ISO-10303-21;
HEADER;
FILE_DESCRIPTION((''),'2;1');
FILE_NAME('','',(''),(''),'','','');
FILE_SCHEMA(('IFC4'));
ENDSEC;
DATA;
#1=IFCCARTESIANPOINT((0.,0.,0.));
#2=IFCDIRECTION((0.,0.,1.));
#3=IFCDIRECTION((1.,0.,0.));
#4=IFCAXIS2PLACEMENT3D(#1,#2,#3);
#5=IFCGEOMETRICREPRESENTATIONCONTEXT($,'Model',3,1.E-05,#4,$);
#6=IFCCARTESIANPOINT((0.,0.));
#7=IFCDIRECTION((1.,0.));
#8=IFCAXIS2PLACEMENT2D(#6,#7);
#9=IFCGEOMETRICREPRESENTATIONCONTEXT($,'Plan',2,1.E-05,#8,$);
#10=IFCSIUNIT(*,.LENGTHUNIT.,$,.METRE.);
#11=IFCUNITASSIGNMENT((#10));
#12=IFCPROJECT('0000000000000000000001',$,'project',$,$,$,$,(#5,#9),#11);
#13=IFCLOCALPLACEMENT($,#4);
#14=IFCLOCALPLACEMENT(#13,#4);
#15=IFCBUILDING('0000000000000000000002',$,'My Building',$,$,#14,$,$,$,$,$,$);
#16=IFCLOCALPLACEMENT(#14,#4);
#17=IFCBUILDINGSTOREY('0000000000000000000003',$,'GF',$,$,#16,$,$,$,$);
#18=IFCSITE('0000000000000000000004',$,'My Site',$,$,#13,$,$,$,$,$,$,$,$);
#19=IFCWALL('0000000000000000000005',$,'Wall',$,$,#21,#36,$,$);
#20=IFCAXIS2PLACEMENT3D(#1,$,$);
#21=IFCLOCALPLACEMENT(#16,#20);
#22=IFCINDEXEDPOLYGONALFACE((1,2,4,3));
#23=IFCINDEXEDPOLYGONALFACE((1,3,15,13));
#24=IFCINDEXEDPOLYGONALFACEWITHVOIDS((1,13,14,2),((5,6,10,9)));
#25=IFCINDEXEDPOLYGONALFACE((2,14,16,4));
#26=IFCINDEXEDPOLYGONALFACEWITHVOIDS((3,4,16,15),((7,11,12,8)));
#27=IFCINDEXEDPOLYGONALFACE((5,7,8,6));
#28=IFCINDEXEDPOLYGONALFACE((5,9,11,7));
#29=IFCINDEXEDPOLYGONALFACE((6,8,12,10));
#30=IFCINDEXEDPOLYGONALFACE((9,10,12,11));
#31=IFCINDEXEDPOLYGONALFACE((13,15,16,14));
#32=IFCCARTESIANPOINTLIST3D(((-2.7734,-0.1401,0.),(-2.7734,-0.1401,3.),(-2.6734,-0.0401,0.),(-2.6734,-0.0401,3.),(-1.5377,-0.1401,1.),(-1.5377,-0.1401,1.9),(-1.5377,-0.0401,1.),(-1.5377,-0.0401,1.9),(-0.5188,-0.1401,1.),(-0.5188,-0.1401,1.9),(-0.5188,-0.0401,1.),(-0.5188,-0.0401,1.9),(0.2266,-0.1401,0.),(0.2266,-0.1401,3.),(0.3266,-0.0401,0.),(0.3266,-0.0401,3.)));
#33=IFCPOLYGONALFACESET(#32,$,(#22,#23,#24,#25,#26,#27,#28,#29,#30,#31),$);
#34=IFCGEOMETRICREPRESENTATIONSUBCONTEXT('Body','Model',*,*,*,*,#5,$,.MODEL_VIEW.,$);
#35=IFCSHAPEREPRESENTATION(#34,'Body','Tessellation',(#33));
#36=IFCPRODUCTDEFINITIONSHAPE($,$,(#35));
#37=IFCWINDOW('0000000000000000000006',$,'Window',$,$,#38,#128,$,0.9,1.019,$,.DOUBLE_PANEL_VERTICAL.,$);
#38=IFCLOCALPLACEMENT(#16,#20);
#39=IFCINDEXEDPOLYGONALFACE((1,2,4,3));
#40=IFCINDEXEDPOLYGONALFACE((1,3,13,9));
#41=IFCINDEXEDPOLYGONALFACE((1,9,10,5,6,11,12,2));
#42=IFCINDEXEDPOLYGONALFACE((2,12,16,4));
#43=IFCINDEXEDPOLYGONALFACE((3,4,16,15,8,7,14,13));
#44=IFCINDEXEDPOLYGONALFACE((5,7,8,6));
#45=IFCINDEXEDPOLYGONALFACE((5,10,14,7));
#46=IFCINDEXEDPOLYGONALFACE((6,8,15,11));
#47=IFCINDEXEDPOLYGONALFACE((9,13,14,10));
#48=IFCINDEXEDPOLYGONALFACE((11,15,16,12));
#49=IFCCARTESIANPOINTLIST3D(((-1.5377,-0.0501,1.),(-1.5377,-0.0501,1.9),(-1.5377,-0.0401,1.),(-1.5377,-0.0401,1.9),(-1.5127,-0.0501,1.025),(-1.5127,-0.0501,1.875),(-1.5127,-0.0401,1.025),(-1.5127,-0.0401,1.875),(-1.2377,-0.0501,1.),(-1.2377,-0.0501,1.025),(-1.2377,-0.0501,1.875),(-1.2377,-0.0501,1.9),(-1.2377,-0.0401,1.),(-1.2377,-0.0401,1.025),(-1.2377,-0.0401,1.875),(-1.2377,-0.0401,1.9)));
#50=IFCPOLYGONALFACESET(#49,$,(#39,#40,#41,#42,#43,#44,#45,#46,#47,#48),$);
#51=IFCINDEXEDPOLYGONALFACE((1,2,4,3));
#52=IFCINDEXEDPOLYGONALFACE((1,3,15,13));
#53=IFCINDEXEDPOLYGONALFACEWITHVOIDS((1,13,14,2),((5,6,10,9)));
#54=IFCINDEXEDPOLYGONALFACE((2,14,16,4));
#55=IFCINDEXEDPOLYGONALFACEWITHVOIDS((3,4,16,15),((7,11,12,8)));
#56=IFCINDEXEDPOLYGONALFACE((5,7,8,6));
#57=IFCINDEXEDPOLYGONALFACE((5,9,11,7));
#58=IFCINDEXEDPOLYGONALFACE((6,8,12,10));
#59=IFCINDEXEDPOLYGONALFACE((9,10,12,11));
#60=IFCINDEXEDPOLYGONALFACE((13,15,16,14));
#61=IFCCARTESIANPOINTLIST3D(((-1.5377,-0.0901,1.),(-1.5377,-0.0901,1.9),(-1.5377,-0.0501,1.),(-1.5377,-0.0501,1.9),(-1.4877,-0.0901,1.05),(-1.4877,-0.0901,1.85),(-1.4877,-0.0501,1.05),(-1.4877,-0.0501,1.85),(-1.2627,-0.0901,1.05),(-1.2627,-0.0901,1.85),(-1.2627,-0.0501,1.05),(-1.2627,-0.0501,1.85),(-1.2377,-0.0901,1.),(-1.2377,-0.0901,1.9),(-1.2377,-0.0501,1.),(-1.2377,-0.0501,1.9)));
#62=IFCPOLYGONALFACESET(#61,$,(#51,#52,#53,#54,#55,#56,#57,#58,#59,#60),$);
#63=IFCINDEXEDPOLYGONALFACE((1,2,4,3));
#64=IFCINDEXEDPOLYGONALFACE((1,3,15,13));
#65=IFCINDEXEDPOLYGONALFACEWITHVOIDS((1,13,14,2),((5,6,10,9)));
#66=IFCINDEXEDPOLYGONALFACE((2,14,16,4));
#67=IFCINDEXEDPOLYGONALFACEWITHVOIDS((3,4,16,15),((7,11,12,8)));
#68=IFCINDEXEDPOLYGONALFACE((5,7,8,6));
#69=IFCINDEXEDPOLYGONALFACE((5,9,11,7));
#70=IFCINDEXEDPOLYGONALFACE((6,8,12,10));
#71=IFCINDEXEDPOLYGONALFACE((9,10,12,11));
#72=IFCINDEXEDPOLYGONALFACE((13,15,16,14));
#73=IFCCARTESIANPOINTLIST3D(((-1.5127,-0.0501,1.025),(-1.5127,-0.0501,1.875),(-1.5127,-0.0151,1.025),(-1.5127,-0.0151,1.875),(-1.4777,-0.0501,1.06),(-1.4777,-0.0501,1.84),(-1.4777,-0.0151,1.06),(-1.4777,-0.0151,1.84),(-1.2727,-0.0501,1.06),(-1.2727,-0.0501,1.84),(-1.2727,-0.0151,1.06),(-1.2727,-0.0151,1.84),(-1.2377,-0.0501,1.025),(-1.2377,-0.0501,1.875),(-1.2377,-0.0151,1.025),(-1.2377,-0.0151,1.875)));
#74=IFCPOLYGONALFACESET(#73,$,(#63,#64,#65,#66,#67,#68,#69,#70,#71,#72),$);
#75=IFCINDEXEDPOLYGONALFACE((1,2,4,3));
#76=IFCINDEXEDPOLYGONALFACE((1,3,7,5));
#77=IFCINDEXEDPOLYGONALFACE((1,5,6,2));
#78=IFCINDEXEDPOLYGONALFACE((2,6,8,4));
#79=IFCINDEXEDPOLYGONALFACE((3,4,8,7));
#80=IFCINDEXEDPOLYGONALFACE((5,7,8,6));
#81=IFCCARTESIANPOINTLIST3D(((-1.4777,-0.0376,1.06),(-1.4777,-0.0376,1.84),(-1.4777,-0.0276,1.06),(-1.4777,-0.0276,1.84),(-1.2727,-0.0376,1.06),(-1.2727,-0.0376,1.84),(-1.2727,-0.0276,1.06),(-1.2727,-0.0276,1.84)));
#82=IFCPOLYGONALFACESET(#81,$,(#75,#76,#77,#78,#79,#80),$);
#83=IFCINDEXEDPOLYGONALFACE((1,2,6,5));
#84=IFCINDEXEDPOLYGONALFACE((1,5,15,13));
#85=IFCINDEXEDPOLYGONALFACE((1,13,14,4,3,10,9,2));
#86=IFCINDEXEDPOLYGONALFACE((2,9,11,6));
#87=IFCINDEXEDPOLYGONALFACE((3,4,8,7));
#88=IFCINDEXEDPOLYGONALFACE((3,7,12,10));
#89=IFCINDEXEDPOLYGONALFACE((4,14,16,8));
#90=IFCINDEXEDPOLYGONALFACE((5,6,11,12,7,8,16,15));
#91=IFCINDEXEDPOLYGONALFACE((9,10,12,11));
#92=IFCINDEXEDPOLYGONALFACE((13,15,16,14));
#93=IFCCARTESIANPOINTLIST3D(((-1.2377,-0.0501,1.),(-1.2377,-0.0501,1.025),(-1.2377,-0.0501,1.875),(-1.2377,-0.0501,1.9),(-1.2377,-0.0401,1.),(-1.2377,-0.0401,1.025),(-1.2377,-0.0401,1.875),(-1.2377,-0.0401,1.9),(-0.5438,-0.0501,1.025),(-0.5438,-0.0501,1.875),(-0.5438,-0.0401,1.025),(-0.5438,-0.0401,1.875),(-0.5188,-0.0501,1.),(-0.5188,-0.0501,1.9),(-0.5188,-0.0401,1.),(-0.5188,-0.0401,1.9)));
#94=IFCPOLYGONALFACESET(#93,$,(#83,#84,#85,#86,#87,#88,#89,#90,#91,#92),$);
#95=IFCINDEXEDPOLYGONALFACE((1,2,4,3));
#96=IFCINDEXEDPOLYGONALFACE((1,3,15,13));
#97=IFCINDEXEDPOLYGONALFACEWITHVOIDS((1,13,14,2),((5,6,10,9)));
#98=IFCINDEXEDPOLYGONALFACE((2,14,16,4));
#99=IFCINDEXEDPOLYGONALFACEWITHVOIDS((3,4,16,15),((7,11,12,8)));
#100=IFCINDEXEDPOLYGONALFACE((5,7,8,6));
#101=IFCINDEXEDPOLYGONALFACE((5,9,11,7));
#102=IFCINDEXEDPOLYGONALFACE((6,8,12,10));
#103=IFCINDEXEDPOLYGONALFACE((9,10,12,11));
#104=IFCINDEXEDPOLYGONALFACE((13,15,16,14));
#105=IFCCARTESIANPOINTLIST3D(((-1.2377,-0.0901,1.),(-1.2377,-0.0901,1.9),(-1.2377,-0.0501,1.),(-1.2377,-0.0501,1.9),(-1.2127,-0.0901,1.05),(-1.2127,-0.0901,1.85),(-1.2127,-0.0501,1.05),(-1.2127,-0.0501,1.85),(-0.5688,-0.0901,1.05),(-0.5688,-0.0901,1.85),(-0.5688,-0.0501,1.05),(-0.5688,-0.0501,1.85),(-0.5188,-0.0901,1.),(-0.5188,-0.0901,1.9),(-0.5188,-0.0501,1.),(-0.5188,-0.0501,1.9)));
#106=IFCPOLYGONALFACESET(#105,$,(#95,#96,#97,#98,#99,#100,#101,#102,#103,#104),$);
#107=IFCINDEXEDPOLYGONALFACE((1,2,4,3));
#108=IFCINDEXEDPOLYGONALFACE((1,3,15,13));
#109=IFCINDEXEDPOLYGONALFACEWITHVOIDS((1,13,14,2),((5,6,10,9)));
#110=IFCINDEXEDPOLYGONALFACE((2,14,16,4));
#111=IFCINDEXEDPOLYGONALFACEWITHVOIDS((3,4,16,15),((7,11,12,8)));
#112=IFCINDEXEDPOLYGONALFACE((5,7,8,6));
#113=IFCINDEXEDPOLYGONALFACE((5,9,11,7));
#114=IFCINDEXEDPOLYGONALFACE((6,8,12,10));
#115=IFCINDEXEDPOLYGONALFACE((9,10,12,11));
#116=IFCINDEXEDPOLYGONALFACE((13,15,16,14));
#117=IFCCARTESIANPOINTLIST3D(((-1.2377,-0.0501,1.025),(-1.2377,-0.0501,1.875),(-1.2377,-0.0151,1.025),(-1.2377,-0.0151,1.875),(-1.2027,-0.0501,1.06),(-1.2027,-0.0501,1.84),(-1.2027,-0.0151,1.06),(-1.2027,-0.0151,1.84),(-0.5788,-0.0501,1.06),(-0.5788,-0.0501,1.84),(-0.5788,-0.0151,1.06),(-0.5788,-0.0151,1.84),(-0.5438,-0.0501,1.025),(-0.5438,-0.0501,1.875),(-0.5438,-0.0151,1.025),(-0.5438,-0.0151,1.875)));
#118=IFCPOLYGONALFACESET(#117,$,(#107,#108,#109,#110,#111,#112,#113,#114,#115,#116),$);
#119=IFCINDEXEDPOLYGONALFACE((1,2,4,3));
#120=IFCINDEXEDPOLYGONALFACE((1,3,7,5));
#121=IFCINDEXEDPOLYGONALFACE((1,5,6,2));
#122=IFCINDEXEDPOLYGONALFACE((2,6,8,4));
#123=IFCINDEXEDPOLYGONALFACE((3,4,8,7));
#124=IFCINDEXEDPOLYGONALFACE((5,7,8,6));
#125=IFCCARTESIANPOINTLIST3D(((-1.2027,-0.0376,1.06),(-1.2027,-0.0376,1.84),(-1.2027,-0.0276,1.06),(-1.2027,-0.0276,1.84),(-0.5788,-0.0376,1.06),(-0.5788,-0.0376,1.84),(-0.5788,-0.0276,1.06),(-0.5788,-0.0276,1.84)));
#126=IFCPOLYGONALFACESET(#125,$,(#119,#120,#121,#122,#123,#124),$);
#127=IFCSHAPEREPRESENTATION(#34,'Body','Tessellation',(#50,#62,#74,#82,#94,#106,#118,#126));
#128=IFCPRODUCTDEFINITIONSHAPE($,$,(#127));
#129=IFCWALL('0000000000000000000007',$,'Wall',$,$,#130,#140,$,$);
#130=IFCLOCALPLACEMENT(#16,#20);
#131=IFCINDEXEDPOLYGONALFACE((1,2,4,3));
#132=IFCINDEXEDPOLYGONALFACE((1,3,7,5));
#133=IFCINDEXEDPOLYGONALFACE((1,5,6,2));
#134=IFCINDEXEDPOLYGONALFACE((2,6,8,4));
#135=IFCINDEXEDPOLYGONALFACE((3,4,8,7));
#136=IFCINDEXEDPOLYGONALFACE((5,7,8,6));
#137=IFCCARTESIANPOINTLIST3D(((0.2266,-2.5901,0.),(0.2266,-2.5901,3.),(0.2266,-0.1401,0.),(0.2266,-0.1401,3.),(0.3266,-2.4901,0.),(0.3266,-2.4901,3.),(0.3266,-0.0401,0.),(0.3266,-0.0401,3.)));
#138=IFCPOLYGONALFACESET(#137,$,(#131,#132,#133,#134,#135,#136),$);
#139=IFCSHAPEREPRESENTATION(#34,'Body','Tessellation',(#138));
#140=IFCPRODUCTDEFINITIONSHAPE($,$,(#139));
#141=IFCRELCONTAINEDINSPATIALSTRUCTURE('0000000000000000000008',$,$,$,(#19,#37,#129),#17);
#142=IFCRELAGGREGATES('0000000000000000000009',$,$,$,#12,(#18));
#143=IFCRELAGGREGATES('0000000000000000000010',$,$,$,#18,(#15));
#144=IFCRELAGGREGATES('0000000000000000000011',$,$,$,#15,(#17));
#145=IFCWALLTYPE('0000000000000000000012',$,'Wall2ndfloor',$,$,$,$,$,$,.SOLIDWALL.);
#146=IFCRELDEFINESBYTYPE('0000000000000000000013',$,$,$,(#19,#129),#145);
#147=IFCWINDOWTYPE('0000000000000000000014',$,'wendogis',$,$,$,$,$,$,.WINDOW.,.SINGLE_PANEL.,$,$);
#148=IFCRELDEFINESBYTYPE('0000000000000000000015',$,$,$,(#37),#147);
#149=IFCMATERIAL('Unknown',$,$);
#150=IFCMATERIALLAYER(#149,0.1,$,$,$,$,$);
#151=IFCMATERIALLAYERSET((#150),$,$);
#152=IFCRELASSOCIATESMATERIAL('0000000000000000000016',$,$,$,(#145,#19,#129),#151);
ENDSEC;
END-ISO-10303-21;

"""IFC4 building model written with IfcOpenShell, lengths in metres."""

from ifc_helpers import new_model, entity, si_unit, frame, origin_with_axes, origin_2d_with_axis, place, context, subcontext, project, spatial, line, indexed_curve, outline, extrude, shape, source, transform, mapped, material, layer, layer_set, layer_usage, type_object, type_shapes, element, fill, save


model = new_model("IFC4")

# Units and contexts
model_context = context("Model", 3, precision=1e-05, world=origin_with_axes())
plan_context = context("Plan", 2, precision=1e-05, world=origin_2d_with_axis())
body_context_1 = subcontext(model_context, "Body", "Model", "MODEL_VIEW")
body_context_2 = subcontext(plan_context, "Body", "Plan", "PLAN_VIEW")
ifc_project = project(units=[si_unit("LENGTHUNIT", "METRE")], contexts=[model_context, plan_context])

# Site, building, storey
site_placement = place(None, origin_with_axes())
site = spatial("IfcSite", under=ifc_project, at=site_placement, Name="My Site")
building_placement = place(site_placement, origin_with_axes())
building = spatial("IfcBuilding", under=site, at=building_placement, Name="My Building")
storey_placement = place(building_placement, origin_with_axes())
storey = spatial("IfcBuildingStorey", under=building, at=storey_placement, Name="GF")

# Shared definitions
ifc_material = material(Name="Unknown")

# Shared definitions
ifc_layer_1 = layer(ifc_material, 0.1)
ifc_layer_set_1 = layer_set([ifc_layer_1])
wall_type_1 = type_object("IfcWallType", Name="Wall2ndfloor", PredefinedType="SOLIDWALL", material=ifc_layer_set_1)

# Wall, opening, window
ifc_layer_usage_1 = layer_usage(ifc_layer_set_1, "AXIS2", "POSITIVE", 0.0)
wall_1_placement = place(storey_placement, frame((-2.7734, -0.1401, 0.0), z_axis=(0.0, 0.0, 1.0), x_axis=(1.0, 0.0, 0.0)))
wall_1 = element("IfcWall", 1, at=wall_1_placement, inside=storey, type_object=wall_type_1, material=ifc_layer_usage_1, Name="Wall", context=body_context_1, shape_type="SweptSolid", body=[
    extrude(outline(indexed_curve([(0.0, 0.0), (0.1, 0.1), (3.1, 0.1), (3.0, 0.0)], segments=[line(1, 2, 3, 4, 1)])), origin_with_axes(), (0.0, 0.0, 1.0), 3.0),
])
shared_shape_1 = source(origin_with_axes(), body_context_1, "Body", "SweptSolid", [
    extrude(outline(indexed_curve([(0.0, 0.0), (1.019, 0.0), (1.019, 0.9), (0.0, 0.9)], segments=[line(1, 2, 3, 4, 1)])), frame((0.0, -0.6, 0.0), z_axis=(0.0, -1.0, 0.0), x_axis=(1.0, 0.0, 0.0)), (0.0, 0.0, -1.0), 1.2),
])
opening_1_placement = place(wall_1_placement, frame((1.2356, 0.0, 1.0), z_axis=(0.0, 0.0, 1.0), x_axis=(1.0, 0.0, 0.0)))
opening_1 = element("IfcOpeningElement", 2, at=opening_1_placement, cuts=wall_1, PredefinedType="OPENING", context=body_context_1, shape_type="MappedRepresentation", body=[
    mapped(shared_shape_1, transform((0.0, 0.0, 0.0), x_axis=(1.0, 0.0, 0.0), y_axis=(0.0, 1.0, 0.0), z_axis=(0.0, 0.0, 1.0), scale=1.0)),
])
window_type_1 = type_object("IfcWindowType", Name="wendogis", PartitioningType="SINGLE_PANEL", PredefinedType="WINDOW")
shared_shape_2 = source(origin_with_axes(), body_context_1, "Body", "SweptSolid", [
    extrude(outline(indexed_curve([(0.3, 0.0), (0.0, 0.0), (0.0, 0.9), (0.3, 0.9), (0.3, 0.875), (0.025, 0.875), (0.025, 0.025), (0.3, 0.025)], segments=[line(1, 2, 3, 4, 5, 6, 7, 8, 1)])), frame((0.0, 0.09, 0.0), z_axis=(0.0, -1.0, 0.0), x_axis=(1.0, 0.0, 0.0)), (0.0, 0.0, -1.0), 0.01),
    extrude(outline(indexed_curve([(0.0, 0.0), (0.3, 0.0), (0.3, 0.9), (0.0, 0.9)], segments=[line(1, 2, 3, 4, 1)]), holes=[indexed_curve([(0.05, 0.05), (0.275, 0.05), (0.275, 0.85), (0.05, 0.85)], segments=[line(1, 2, 3, 4, 1)])]), frame((0.0, 0.05, 0.0), z_axis=(0.0, -1.0, 0.0), x_axis=(1.0, 0.0, 0.0)), (0.0, 0.0, -1.0), 0.04),
    extrude(outline(indexed_curve([(0.0, 0.0), (0.275, 0.0), (0.275, 0.85), (0.0, 0.85)], segments=[line(1, 2, 3, 4, 1)]), holes=[indexed_curve([(0.035, 0.035), (0.24, 0.035), (0.24, 0.815), (0.035, 0.815)], segments=[line(1, 2, 3, 4, 1)])]), frame((0.025, 0.09, 0.025), z_axis=(0.0, -1.0, 0.0), x_axis=(1.0, 0.0, 0.0)), (0.0, 0.0, -1.0), 0.035),
    extrude(outline(indexed_curve([(0.035, 0.035), (0.24, 0.035), (0.24, 0.815), (0.035, 0.815)], segments=[line(1, 2, 3, 4, 1)])), frame((0.025, 0.1025, 0.025), z_axis=(0.0, -1.0, 0.0), x_axis=(1.0, 0.0, 0.0)), (0.0, 0.0, -1.0), 0.01),
    extrude(outline(indexed_curve([(0.0, 0.9), (0.719, 0.9), (0.719, 0.0), (0.0, 0.0), (0.0, 0.025), (0.694, 0.025), (0.694, 0.875), (0.0, 0.875)], segments=[line(1, 2, 3, 4, 5, 6, 7, 8, 1)])), frame((0.3, 0.09, 0.0), z_axis=(0.0, -1.0, 0.0), x_axis=(1.0, 0.0, 0.0)), (0.0, 0.0, -1.0), 0.01),
    extrude(outline(indexed_curve([(0.0, 0.0), (0.719, 0.0), (0.719, 0.9), (0.0, 0.9)], segments=[line(1, 2, 3, 4, 1)]), holes=[indexed_curve([(0.025, 0.05), (0.669, 0.05), (0.669, 0.85), (0.025, 0.85)], segments=[line(1, 2, 3, 4, 1)])]), frame((0.3, 0.05, 0.0), z_axis=(0.0, -1.0, 0.0), x_axis=(1.0, 0.0, 0.0)), (0.0, 0.0, -1.0), 0.04),
    extrude(outline(indexed_curve([(0.0, 0.0), (0.694, 0.0), (0.694, 0.85), (0.0, 0.85)], segments=[line(1, 2, 3, 4, 1)]), holes=[indexed_curve([(0.035, 0.035), (0.659, 0.035), (0.659, 0.815), (0.035, 0.815)], segments=[line(1, 2, 3, 4, 1)])]), frame((0.3, 0.09, 0.025), z_axis=(0.0, -1.0, 0.0), x_axis=(1.0, 0.0, 0.0)), (0.0, 0.0, -1.0), 0.035),
    extrude(outline(indexed_curve([(0.035, 0.035), (0.659, 0.035), (0.659, 0.815), (0.035, 0.815)], segments=[line(1, 2, 3, 4, 1)])), frame((0.3, 0.1025, 0.025), z_axis=(0.0, -1.0, 0.0), x_axis=(1.0, 0.0, 0.0)), (0.0, 0.0, -1.0), 0.01),
])
shared_shape_3 = source(origin_with_axes(), body_context_2, "Body", "Curve2D", [
    entity("IfcIndexedPolyCurve", entity("IfcCartesianPointList2D", [[0.05, 0.05], [0.275, 0.05]])),
    entity("IfcIndexedPolyCurve", entity("IfcCartesianPointList2D", [[0.0, 0.1], [0.025, 0.1], [0.025, 0.09], [0.05, 0.09], [0.05, 0.05], [0.0, 0.05]]), [entity("IfcLineIndex", [1, 2, 3, 4, 5, 6, 1])]),
    entity("IfcIndexedPolyCurve", entity("IfcCartesianPointList2D", [[0.3, 0.1], [0.3, 0.1], [0.3, 0.09], [0.275, 0.09], [0.275, 0.05], [0.3, 0.05]])),
    entity("IfcIndexedPolyCurve", entity("IfcCartesianPointList2D", [[0.025, 0.09], [0.06, 0.09], [0.06, 0.125], [0.025, 0.125]]), [entity("IfcLineIndex", [1, 2, 3, 4, 1])]),
    entity("IfcIndexedPolyCurve", entity("IfcCartesianPointList2D", [[0.3, 0.09], [0.265, 0.09], [0.265, 0.125], [0.3, 0.125]]), [entity("IfcLineIndex", [1, 2, 3, 4, 1])]),
    entity("IfcIndexedPolyCurve", entity("IfcCartesianPointList2D", [[0.06, 0.09], [0.265, 0.09]])),
    entity("IfcIndexedPolyCurve", entity("IfcCartesianPointList2D", [[0.06, 0.125], [0.265, 0.125]])),
    entity("IfcIndexedPolyCurve", entity("IfcCartesianPointList2D", [[0.06, 0.1075], [0.265, 0.1075]])),
    entity("IfcIndexedPolyCurve", entity("IfcCartesianPointList2D", [[0.325, 0.05], [0.969, 0.05]])),
    entity("IfcIndexedPolyCurve", entity("IfcCartesianPointList2D", [[0.3, 0.1], [0.3, 0.1], [0.3, 0.09], [0.325, 0.09], [0.325, 0.05], [0.3, 0.05]])),
    entity("IfcIndexedPolyCurve", entity("IfcCartesianPointList2D", [[1.019, 0.1], [0.994, 0.1], [0.994, 0.09], [0.969, 0.09], [0.969, 0.05], [1.019, 0.05]]), [entity("IfcLineIndex", [1, 2, 3, 4, 5, 6, 1])]),
    entity("IfcIndexedPolyCurve", entity("IfcCartesianPointList2D", [[0.3, 0.09], [0.335, 0.09], [0.335, 0.125], [0.3, 0.125]]), [entity("IfcLineIndex", [1, 2, 3, 4, 1])]),
    entity("IfcIndexedPolyCurve", entity("IfcCartesianPointList2D", [[0.994, 0.09], [0.959, 0.09], [0.959, 0.125], [0.994, 0.125]]), [entity("IfcLineIndex", [1, 2, 3, 4, 1])]),
    entity("IfcIndexedPolyCurve", entity("IfcCartesianPointList2D", [[0.335, 0.09], [0.959, 0.09]])),
    entity("IfcIndexedPolyCurve", entity("IfcCartesianPointList2D", [[0.335, 0.125], [0.959, 0.125]])),
    entity("IfcIndexedPolyCurve", entity("IfcCartesianPointList2D", [[0.335, 0.1075], [0.959, 0.1075]])),
])
type_shapes(window_type_1, [shared_shape_2, shared_shape_3])
window_1_placement = place(opening_1_placement, frame((0.0, 0.0, 0.0), z_axis=(0.0, 0.0, 1.0), x_axis=(1.0, 0.0, 0.0)))
window_1 = element("IfcWindow", 3, at=window_1_placement, inside=storey, type_object=window_type_1, Name="Window", OverallHeight=0.9, OverallWidth=1.019, PartitioningType="DOUBLE_PANEL_VERTICAL", shapes=[
    shape(body_context_1, "Body", "MappedRepresentation", [mapped(shared_shape_2, transform((0.0, 0.0, 0.0), x_axis=(1.0, 0.0, 0.0), y_axis=(0.0, 1.0, 0.0), z_axis=(0.0, 0.0, 1.0), scale=1.0))]),
    shape(body_context_2, "Body", "MappedRepresentation", [mapped(shared_shape_3, transform((0.0, 0.0, 0.0), x_axis=(1.0, 0.0, 0.0), y_axis=(0.0, 1.0, 0.0), z_axis=(0.0, 0.0, 1.0), scale=1.0))]),
])
fill(opening_1, window_1)

# Wall
ifc_layer_usage_2 = layer_usage(ifc_layer_set_1, "AXIS2", "POSITIVE", 0.0)
wall_2_placement = place(storey_placement, frame((0.2266, -0.1401, 0.0), z_axis=(0.0, 0.0, 1.0), x_axis=(0.0, -1.0, 0.0)))
element("IfcWall", 4, at=wall_2_placement, inside=storey, type_object=wall_type_1, material=ifc_layer_usage_2, Name="Wall", context=body_context_1, shape_type="SweptSolid", body=[
    extrude(outline(indexed_curve([(0.0, 0.0), (-0.1, 0.1), (2.35, 0.1), (2.45, 0.0)], segments=[line(1, 2, 3, 4, 1)])), origin_with_axes(), (0.0, 0.0, 1.0), 3.0),
])

save(model, "model.ifc")
